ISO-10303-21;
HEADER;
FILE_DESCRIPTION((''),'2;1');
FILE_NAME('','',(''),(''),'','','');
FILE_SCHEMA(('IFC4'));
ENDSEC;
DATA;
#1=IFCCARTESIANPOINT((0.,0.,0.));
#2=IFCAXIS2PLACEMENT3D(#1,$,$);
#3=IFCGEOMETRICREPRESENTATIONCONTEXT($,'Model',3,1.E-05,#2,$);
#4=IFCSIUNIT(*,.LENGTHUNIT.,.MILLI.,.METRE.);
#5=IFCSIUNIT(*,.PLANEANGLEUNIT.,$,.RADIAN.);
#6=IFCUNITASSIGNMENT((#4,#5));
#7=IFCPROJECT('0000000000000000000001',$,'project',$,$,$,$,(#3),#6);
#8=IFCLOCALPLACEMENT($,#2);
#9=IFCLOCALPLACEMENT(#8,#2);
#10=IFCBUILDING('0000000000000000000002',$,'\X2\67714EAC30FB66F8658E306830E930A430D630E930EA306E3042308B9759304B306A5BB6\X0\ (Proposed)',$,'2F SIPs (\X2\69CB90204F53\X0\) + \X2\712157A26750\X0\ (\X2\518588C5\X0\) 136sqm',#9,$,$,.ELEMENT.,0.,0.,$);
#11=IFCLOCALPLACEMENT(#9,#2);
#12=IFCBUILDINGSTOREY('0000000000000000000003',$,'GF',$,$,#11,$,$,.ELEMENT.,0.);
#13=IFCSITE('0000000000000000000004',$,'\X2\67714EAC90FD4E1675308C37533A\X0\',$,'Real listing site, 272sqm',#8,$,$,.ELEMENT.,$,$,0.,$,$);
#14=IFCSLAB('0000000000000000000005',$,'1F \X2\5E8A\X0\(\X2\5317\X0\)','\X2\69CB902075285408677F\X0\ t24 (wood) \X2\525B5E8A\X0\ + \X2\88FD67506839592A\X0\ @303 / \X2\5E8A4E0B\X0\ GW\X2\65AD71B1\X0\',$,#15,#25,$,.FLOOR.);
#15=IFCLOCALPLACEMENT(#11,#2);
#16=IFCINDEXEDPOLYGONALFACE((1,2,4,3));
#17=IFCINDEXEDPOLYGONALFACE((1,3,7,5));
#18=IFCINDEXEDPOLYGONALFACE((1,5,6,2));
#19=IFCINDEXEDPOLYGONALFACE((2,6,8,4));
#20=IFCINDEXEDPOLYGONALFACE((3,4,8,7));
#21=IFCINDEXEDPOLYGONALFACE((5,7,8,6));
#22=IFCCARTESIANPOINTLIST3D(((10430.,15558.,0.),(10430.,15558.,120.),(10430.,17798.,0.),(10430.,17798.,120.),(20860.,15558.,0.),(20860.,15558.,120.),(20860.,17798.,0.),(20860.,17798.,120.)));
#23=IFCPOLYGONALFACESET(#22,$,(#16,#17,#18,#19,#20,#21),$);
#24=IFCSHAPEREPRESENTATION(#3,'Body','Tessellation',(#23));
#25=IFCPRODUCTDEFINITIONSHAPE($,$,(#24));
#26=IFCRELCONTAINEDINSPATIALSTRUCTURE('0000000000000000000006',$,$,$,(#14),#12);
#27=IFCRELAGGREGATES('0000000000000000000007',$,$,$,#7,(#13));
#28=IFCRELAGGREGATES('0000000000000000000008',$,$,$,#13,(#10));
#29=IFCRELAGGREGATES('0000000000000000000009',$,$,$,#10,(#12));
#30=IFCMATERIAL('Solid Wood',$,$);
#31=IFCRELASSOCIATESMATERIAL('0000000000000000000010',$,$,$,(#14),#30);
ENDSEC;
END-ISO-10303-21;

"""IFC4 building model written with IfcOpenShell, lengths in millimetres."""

from ifc_helpers import new_model, si_unit, frame, frame_2d, origin, place, context, project, spatial, rectangle, extrude, material, element, save


model = new_model("IFC4")

# Units and contexts
model_context = context("Model", 3, precision=1e-05, world=origin())
ifc_project = project(units=[si_unit("LENGTHUNIT", "METRE", prefix="MILLI"), si_unit("PLANEANGLEUNIT", "RADIAN")], contexts=[model_context])

# Site, building, storey
site_placement = place(None, origin())
site = spatial("IfcSite", under=ifc_project, at=site_placement, Name="東京都世田谷区", ObjectType="Real listing site, 272sqm", CompositionType="ELEMENT", RefElevation=0.0)
building_placement = place(site_placement, origin())
building = spatial("IfcBuilding", under=site, at=building_placement, Name="東京・書斎とライブラリのある静かな家 (Proposed)", ObjectType="2F SIPs (構造体) + 無垢材 (内装) 136sqm", CompositionType="ELEMENT", ElevationOfRefHeight=0.0, ElevationOfTerrain=0.0)
storey_placement = place(building_placement, origin())
storey = spatial("IfcBuildingStorey", under=building, at=storey_placement, Name="GF", CompositionType="ELEMENT", Elevation=0.0)

# Slab
ifc_material_1 = material(Name="Solid Wood")
slab_1_placement = place(storey_placement, frame((5215.0, 7779.0, 0.0)))
element("IfcSlab", 1, at=slab_1_placement, inside=storey, material=ifc_material_1, Name="1F 床(北)", Description="構造用合板 t24 (wood) 剛床 + 製材根太 @303 / 床下 GW断熱", PredefinedType="FLOOR", context=model_context, shape_type="SweptSolid", body=[
    extrude(rectangle(XDim=10430.0, YDim=2240.0, at=frame_2d((5215.0, 1120.0))), frame((5215.0, 7779.0, 0.0)), (0.0, 0.0, 1.0), 120.0),
])

save(model, "model.ifc")
